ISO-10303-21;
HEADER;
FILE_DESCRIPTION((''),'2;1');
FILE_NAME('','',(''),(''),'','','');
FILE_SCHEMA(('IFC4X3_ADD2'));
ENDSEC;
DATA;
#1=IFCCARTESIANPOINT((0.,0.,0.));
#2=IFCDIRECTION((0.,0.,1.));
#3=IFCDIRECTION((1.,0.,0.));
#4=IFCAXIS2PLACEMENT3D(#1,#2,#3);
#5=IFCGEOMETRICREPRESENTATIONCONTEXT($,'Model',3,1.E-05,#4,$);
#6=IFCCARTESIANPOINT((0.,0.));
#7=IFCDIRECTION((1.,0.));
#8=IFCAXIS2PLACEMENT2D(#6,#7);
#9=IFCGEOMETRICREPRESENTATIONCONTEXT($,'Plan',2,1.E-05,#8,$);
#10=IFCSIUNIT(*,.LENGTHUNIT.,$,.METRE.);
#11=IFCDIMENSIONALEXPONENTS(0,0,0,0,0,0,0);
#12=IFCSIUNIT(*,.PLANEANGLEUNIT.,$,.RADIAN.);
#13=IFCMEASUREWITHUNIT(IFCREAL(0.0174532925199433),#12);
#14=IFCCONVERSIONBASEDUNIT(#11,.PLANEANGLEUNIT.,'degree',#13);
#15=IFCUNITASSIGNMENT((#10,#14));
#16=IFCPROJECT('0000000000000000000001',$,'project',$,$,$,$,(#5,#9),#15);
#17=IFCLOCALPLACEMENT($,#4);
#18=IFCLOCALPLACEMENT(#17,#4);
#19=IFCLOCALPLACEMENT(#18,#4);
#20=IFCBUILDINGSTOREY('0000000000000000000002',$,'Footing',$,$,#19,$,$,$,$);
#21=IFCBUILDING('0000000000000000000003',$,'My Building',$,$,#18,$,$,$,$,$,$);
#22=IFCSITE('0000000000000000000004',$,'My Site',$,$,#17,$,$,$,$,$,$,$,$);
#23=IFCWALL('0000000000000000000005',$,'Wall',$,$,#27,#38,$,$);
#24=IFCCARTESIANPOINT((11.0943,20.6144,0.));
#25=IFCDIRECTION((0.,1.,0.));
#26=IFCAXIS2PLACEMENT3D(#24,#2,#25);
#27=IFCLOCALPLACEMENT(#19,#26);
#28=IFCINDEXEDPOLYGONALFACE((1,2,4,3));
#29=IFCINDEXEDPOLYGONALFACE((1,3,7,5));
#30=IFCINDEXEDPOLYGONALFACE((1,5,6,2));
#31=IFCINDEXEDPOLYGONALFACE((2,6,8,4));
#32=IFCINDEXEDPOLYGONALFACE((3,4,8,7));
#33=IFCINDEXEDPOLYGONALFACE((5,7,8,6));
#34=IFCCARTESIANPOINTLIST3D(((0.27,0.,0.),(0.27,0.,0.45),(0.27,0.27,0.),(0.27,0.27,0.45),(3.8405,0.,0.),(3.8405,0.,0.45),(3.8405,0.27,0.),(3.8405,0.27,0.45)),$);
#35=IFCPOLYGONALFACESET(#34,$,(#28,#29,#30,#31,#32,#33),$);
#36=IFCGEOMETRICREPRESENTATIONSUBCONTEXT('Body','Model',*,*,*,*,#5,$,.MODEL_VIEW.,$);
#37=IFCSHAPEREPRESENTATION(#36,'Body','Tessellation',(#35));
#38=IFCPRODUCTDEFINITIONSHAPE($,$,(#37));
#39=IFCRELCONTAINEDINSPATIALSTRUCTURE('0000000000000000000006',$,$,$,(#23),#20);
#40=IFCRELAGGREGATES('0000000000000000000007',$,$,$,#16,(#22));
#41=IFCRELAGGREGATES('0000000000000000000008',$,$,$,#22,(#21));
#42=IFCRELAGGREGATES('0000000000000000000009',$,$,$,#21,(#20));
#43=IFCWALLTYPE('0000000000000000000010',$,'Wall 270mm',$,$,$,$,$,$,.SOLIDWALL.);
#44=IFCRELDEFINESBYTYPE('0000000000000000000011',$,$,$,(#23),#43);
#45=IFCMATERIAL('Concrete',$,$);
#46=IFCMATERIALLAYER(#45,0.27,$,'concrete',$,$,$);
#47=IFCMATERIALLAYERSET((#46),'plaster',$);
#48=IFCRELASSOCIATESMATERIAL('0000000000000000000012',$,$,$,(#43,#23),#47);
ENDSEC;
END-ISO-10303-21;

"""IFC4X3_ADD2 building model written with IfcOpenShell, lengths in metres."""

from ifc_helpers import new_model, entity, si_unit, converted_unit, frame, origin_with_axes, origin_2d_with_axis, place, context, subcontext, project, spatial, line, indexed_curve, outline, extrude, material, layer, layer_set, layer_usage, type_object, element, save


model = new_model("IFC4X3_ADD2")

# Units and contexts
model_context = context("Model", 3, precision=1e-05, world=origin_with_axes())
plan_context = context("Plan", 2, precision=1e-05, world=origin_2d_with_axis())
body_context = subcontext(model_context, "Body", "Model", "MODEL_VIEW")
ifc_project = project(units=[si_unit("LENGTHUNIT", "METRE"), converted_unit("PLANEANGLEUNIT", "degree", entity("IfcReal", 0.0174532925199433), si_unit("PLANEANGLEUNIT", "RADIAN"), dimensions=[0, 0, 0, 0, 0, 0, 0])], contexts=[model_context, plan_context])

# Site, building, storey
site_placement = place(None, origin_with_axes())
site = spatial("IfcSite", under=ifc_project, at=site_placement, Name="My Site")
building_placement = place(site_placement, origin_with_axes())
building = spatial("IfcBuilding", under=site, at=building_placement, Name="My Building")
storey_placement = place(building_placement, origin_with_axes())
storey = spatial("IfcBuildingStorey", under=building, at=storey_placement, Name="Footing")

# Wall
ifc_material_1 = material(Name="Concrete")
ifc_layer_1 = layer(ifc_material_1, 0.27, Name="concrete")
ifc_layer_set_1 = layer_set([ifc_layer_1], Name="plaster")
wall_type_1 = type_object("IfcWallType", Name="Wall 270mm", PredefinedType="SOLIDWALL", material=ifc_layer_set_1)
ifc_layer_usage_1 = layer_usage(ifc_layer_set_1, "AXIS2", "POSITIVE", 0.0)
wall_1_placement = place(storey_placement, frame((11.0943, 20.6144, 0.0), z_axis=(0.0, 0.0, 1.0), x_axis=(0.0, 1.0, 0.0)))
element("IfcWall", 1, at=wall_1_placement, inside=storey, type_object=wall_type_1, material=ifc_layer_usage_1, Name="Wall", context=body_context, shape_type="SweptSolid", body=[
    extrude(outline(indexed_curve([(0.27, 0.0), (0.27, 0.27), (3.8405, 0.27), (3.8405, 0.0)], segments=[line(1, 2, 3, 4, 1)])), origin_with_axes(), (0.0, 0.0, 1.0), 0.45),
])

save(model, "model.ifc")
